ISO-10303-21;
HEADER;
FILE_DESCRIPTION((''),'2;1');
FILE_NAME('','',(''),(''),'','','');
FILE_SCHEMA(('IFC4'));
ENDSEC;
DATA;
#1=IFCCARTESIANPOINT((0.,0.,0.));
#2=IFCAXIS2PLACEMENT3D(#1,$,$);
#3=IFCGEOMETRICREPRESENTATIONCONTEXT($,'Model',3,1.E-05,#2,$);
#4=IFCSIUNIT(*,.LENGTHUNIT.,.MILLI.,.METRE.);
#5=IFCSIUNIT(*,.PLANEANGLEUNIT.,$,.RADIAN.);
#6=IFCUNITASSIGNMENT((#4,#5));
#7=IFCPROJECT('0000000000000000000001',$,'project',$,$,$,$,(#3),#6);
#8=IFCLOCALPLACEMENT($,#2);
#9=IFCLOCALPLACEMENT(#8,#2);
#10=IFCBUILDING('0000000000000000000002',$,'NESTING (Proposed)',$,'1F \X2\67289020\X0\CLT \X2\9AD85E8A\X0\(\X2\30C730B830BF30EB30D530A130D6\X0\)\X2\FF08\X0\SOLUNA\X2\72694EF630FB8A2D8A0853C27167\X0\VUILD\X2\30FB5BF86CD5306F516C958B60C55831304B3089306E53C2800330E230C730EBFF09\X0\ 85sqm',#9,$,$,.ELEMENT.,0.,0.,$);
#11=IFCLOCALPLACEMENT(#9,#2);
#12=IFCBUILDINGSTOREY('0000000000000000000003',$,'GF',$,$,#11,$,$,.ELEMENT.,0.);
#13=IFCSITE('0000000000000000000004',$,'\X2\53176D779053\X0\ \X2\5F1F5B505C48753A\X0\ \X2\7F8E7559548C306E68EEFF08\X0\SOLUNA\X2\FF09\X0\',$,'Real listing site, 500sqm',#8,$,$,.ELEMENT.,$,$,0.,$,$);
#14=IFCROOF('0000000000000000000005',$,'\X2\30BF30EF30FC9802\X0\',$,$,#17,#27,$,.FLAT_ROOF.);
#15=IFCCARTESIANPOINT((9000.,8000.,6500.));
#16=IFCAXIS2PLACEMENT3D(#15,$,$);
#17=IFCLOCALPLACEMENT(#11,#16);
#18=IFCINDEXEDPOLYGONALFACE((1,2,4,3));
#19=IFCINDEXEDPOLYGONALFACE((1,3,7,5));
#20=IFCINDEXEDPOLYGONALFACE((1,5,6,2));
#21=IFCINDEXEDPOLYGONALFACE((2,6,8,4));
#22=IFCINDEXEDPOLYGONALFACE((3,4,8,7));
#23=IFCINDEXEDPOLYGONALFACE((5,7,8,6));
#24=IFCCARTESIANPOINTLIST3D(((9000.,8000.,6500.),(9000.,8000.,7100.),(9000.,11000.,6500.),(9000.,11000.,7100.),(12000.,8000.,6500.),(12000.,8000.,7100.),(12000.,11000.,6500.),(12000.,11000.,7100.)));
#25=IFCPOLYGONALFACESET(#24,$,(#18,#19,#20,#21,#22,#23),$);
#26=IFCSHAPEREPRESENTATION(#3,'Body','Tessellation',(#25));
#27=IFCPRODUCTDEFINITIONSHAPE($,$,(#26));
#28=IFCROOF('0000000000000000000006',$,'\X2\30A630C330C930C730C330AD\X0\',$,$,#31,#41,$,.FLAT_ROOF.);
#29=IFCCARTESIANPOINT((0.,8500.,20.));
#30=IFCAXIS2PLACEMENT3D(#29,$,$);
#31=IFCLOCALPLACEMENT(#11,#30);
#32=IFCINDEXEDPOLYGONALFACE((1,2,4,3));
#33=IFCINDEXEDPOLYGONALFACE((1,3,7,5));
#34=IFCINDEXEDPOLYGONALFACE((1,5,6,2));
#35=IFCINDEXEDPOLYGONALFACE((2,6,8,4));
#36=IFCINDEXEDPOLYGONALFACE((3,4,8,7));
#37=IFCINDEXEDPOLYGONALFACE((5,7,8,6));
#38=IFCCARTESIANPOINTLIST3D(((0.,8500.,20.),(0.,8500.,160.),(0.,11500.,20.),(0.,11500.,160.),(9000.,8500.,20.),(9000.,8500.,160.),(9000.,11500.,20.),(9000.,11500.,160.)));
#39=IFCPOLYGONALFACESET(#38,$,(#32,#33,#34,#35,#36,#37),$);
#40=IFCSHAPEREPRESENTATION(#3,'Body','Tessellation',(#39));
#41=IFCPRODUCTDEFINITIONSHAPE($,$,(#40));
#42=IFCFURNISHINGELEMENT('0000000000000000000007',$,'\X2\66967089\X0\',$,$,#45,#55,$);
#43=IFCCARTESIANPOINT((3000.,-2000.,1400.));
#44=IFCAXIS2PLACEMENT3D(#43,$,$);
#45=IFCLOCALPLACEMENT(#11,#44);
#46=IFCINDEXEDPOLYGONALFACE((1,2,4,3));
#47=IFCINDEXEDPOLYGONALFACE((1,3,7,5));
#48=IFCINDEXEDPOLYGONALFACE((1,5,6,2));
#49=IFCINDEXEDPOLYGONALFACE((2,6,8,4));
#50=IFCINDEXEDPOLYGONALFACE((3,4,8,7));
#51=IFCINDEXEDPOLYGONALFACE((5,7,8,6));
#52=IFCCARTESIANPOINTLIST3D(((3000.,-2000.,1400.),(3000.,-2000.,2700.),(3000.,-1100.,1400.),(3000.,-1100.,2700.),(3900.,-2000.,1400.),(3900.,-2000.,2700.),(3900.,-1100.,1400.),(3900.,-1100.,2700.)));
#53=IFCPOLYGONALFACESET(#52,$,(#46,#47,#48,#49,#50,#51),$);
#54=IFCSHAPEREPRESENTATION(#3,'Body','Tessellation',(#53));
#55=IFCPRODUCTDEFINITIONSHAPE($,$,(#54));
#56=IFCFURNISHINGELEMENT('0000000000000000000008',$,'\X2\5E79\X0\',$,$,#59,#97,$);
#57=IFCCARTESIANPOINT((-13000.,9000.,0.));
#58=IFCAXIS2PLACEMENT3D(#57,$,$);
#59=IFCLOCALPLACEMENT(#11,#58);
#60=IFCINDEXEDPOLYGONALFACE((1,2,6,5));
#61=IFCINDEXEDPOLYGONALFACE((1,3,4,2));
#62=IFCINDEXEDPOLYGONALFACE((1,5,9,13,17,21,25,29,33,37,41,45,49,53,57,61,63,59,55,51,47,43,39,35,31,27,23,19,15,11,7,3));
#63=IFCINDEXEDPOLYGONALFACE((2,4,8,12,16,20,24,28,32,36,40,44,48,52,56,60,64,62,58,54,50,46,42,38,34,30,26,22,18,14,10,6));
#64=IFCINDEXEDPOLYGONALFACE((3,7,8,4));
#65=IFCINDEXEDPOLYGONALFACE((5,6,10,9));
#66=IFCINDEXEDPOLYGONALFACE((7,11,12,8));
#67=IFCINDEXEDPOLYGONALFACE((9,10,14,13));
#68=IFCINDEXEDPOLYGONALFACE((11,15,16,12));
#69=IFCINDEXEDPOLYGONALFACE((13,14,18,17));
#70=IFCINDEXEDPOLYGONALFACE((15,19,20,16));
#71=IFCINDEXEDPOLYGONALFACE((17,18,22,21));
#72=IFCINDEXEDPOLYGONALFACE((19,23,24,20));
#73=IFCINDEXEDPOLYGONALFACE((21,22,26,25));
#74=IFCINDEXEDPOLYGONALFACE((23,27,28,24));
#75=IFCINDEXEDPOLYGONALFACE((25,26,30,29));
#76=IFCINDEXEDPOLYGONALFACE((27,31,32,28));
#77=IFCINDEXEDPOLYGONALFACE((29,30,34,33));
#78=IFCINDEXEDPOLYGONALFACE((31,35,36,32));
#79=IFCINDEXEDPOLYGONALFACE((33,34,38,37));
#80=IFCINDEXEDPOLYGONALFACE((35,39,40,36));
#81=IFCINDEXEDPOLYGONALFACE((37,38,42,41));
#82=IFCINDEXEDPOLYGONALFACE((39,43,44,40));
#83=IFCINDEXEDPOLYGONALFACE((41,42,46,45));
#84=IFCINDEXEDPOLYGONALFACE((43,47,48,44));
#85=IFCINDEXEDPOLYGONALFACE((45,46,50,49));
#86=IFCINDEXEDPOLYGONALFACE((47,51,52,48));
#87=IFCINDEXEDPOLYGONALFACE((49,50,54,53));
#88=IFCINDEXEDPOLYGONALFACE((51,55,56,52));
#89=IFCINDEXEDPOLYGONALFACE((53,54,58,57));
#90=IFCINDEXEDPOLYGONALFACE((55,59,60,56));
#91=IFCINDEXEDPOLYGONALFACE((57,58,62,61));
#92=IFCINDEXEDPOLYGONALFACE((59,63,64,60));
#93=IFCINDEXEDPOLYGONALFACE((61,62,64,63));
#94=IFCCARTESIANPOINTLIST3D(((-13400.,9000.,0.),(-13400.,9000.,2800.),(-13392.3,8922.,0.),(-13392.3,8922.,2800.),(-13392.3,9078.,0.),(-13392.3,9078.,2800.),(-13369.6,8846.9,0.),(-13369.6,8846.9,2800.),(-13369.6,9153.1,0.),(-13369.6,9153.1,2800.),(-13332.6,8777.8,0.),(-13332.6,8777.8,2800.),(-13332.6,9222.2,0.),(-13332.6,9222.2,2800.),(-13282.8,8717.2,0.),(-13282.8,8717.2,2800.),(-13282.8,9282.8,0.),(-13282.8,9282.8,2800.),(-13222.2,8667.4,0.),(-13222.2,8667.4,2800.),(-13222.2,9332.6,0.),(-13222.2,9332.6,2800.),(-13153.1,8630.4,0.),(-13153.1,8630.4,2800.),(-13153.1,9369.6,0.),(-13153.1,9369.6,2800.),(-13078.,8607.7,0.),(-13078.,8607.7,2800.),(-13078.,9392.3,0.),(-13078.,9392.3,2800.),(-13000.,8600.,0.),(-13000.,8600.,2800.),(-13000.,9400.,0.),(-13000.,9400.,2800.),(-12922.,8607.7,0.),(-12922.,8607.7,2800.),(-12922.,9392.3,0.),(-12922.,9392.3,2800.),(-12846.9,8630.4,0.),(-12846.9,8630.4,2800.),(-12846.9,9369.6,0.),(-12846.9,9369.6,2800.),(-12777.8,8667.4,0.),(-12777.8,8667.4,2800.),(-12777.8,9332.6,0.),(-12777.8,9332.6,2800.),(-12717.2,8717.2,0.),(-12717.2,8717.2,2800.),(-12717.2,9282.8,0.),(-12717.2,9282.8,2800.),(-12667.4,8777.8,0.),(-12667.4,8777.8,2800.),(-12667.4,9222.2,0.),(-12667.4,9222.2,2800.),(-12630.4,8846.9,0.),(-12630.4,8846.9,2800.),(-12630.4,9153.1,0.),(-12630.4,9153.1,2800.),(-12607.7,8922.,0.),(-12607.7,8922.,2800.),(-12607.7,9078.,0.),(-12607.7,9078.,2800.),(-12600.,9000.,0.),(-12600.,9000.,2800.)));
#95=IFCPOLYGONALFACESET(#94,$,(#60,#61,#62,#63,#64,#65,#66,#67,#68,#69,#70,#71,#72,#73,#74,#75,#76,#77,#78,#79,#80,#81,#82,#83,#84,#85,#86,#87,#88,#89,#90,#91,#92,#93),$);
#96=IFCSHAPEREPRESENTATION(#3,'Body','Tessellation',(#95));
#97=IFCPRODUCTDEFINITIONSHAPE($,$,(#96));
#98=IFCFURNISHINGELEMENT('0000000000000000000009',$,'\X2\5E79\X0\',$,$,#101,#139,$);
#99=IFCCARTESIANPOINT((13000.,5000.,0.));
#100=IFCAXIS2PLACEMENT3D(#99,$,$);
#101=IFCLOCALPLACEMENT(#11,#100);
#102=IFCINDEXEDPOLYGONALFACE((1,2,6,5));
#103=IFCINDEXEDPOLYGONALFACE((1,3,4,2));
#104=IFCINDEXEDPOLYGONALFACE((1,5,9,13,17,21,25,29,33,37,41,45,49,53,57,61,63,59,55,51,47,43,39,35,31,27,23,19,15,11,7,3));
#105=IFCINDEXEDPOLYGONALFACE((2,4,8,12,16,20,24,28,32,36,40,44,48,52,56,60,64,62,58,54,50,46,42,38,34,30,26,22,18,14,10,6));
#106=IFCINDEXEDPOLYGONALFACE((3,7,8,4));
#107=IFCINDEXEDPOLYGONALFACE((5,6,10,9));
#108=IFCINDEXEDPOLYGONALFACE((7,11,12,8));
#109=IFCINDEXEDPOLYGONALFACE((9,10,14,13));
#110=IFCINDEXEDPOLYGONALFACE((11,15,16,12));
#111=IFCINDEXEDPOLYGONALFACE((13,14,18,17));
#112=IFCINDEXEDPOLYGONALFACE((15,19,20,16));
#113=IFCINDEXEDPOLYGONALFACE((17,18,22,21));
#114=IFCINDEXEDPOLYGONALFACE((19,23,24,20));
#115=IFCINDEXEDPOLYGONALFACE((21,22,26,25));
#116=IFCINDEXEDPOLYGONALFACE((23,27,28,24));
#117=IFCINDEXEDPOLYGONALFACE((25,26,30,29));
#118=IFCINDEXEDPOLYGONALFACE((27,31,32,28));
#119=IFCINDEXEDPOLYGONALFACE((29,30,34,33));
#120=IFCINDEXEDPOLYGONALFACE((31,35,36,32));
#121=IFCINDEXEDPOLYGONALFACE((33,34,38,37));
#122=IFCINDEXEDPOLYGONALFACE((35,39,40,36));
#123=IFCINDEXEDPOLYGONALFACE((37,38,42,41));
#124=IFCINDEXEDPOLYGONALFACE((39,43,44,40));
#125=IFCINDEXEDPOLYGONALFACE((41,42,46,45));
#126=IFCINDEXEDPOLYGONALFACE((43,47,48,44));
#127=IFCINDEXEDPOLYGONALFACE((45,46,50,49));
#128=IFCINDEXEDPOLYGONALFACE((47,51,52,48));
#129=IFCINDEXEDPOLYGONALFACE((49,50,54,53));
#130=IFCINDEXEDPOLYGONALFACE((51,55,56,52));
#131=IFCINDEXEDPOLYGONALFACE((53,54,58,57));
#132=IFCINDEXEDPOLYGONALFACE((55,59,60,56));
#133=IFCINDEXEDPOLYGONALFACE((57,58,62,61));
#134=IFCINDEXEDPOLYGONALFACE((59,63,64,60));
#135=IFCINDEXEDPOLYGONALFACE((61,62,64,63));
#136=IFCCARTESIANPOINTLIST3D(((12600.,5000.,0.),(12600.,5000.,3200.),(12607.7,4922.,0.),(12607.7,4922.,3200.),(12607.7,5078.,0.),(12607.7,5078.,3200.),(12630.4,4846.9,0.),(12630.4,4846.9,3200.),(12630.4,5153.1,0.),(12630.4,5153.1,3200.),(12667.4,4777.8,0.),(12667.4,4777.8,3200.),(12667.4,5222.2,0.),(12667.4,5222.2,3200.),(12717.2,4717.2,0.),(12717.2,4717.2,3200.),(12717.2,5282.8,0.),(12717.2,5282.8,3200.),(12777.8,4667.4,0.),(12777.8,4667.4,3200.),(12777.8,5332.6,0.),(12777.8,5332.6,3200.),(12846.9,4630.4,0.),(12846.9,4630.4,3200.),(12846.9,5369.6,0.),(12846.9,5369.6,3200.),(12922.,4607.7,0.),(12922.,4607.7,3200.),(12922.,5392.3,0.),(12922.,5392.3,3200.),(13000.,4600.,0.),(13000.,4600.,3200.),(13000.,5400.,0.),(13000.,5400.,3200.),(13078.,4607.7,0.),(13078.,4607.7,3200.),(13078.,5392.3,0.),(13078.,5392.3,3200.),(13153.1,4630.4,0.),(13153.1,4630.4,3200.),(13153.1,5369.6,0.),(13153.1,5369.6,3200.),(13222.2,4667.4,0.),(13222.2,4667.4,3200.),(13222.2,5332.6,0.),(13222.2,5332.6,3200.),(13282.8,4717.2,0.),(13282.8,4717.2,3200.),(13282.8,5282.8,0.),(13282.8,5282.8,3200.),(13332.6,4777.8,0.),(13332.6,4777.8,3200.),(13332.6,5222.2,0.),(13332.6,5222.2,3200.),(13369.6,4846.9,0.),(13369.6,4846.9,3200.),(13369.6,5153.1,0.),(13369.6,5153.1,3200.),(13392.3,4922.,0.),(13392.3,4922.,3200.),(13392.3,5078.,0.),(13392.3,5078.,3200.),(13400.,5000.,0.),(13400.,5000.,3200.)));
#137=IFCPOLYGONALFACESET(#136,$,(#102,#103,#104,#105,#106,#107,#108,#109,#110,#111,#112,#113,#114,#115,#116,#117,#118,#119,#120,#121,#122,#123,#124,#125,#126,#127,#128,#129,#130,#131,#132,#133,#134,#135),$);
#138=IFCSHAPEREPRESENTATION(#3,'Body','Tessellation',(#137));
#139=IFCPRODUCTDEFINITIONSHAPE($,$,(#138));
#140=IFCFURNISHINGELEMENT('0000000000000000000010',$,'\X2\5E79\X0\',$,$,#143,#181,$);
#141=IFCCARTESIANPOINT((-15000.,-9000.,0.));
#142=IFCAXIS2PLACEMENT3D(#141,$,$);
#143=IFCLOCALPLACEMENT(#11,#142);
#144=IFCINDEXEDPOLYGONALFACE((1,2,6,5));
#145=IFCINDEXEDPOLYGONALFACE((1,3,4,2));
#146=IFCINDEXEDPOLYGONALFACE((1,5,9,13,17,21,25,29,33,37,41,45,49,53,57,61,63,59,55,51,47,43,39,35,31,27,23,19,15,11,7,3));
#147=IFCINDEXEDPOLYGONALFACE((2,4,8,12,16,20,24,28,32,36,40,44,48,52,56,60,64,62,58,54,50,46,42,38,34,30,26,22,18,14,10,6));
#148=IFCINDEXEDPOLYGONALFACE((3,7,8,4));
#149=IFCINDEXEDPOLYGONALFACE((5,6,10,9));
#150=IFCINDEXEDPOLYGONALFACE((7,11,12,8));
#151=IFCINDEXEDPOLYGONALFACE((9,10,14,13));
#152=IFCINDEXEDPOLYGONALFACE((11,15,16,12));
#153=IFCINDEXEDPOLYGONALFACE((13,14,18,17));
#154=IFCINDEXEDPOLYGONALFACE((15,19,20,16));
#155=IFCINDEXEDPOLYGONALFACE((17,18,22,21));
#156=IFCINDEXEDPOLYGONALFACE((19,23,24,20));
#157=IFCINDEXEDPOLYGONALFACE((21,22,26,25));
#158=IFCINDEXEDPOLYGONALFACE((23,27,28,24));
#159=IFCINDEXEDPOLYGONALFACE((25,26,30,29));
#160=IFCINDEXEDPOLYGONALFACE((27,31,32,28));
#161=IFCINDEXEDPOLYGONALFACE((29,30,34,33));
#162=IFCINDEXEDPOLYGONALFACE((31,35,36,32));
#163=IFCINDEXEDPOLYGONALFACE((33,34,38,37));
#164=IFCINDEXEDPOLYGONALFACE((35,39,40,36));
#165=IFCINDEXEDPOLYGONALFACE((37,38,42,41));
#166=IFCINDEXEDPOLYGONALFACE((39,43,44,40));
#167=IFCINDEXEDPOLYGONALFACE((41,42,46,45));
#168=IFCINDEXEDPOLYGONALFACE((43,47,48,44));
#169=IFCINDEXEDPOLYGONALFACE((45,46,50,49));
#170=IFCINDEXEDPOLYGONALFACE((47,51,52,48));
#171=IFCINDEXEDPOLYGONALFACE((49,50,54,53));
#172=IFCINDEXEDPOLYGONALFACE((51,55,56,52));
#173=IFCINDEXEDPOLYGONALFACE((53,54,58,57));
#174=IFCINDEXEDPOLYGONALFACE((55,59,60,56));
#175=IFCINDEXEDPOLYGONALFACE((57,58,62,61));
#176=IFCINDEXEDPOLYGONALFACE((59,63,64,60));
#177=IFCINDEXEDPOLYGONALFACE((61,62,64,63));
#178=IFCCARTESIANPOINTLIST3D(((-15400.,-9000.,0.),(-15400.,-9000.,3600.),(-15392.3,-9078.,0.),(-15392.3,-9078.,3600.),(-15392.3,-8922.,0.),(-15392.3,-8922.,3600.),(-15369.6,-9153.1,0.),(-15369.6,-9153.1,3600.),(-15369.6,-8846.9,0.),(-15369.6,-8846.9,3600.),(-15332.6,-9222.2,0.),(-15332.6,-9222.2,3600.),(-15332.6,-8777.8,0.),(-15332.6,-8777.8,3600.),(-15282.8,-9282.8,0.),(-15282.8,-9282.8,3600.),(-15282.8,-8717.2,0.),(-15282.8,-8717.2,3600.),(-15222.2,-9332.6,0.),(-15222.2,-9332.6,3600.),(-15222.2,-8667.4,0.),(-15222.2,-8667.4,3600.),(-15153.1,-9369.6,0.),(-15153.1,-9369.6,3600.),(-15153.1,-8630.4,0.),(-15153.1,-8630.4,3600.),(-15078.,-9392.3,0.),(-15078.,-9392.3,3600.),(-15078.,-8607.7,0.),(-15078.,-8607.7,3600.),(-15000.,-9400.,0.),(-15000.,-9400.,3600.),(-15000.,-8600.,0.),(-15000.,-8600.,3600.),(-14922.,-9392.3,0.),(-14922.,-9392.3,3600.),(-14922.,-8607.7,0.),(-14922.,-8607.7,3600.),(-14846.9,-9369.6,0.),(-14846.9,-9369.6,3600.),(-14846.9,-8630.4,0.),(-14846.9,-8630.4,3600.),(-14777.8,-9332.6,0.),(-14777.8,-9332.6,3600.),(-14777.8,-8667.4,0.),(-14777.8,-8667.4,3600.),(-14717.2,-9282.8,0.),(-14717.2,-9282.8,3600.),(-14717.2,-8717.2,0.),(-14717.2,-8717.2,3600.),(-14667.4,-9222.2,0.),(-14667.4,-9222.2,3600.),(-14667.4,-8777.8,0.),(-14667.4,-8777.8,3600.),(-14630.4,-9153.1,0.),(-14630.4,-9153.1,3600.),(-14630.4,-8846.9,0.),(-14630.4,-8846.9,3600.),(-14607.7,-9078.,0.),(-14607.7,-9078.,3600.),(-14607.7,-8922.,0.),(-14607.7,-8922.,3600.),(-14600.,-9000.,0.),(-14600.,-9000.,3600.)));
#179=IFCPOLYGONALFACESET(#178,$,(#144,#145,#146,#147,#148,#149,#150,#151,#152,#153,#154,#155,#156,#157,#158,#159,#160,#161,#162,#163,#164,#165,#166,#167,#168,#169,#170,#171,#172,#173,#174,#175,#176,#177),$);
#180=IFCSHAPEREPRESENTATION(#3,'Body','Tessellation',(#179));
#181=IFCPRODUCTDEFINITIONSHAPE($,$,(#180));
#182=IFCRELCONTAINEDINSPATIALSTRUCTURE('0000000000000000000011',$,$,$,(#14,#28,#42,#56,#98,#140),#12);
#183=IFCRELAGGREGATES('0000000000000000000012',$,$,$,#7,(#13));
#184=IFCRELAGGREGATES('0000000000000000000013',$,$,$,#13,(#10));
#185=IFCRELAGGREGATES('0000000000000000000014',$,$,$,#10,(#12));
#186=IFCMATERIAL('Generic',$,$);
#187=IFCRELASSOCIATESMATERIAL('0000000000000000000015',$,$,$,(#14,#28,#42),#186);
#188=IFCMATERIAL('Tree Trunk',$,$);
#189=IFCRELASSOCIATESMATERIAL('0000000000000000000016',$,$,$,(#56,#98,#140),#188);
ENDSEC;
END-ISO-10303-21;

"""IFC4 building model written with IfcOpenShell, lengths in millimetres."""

from ifc_helpers import new_model, si_unit, frame, frame_2d, origin, origin_2d, place, context, project, spatial, rectangle, circle, extrude, material, element, save


model = new_model("IFC4")

# Units and contexts
model_context = context("Model", 3, precision=1e-05, world=origin())
ifc_project = project(units=[si_unit("LENGTHUNIT", "METRE", prefix="MILLI"), si_unit("PLANEANGLEUNIT", "RADIAN")], contexts=[model_context])

# Site, building, storey
site_placement = place(None, origin())
site = spatial("IfcSite", under=ifc_project, at=site_placement, Name="北海道 弟子屈町 美留和の森（SOLUNA）", ObjectType="Real listing site, 500sqm", CompositionType="ELEMENT", RefElevation=0.0)
building_placement = place(site_placement, origin())
building = spatial("IfcBuilding", under=site, at=building_placement, Name="NESTING (Proposed)", ObjectType="1F 木造CLT 高床(デジタルファブ)（SOLUNA物件・設計参照VUILD・寸法は公開情報からの参考モデル） 85sqm", CompositionType="ELEMENT", ElevationOfRefHeight=0.0, ElevationOfTerrain=0.0)
storey_placement = place(building_placement, origin())
storey = spatial("IfcBuildingStorey", under=building, at=storey_placement, Name="GF", CompositionType="ELEMENT", Elevation=0.0)

# Shared definitions
ifc_material_1 = material(Name="Generic")

# Roofs
roof_1_placement = place(storey_placement, frame((9000.0, 8000.0, 6500.0)))
element("IfcRoof", 1, at=roof_1_placement, inside=storey, material=ifc_material_1, Name="タワー頂", PredefinedType="FLAT_ROOF", context=model_context, shape_type="SweptSolid", body=[
    extrude(rectangle(XDim=3000.0, YDim=3000.0, at=frame_2d((1500.0, 1500.0))), frame((9000.0, 8000.0, 6500.0)), (0.0, 0.0, 1.0), 600.0),
])
roof_2_placement = place(storey_placement, frame((0.0, 8500.0, 20.0)))
element("IfcRoof", 2, at=roof_2_placement, inside=storey, material=ifc_material_1, Name="ウッドデッキ", PredefinedType="FLAT_ROOF", context=model_context, shape_type="SweptSolid", body=[
    extrude(rectangle(XDim=9000.0, YDim=3000.0, at=frame_2d((4500.0, 1500.0))), frame((0.0, 8500.0, 20.0)), (0.0, 0.0, 1.0), 140.0),
])

# Furnishing elements
furnishing_1_placement = place(storey_placement, frame((3000.0, -2000.0, 1400.0)))
element("IfcFurnishingElement", 3, at=furnishing_1_placement, inside=storey, material=ifc_material_1, Name="暖炉", context=model_context, shape_type="SweptSolid", body=[
    extrude(rectangle(XDim=900.0, YDim=900.0, at=frame_2d((450.0, 450.0))), frame((3000.0, -2000.0, 1400.0)), (0.0, 0.0, 1.0), 1300.0),
])
ifc_material_2 = material(Name="Tree Trunk")
furnishing_2_placement = place(storey_placement, frame((-13000.0, 9000.0, 0.0)))
element("IfcFurnishingElement", 4, at=furnishing_2_placement, inside=storey, material=ifc_material_2, Name="幹", context=model_context, shape_type="SweptSolid", body=[
    extrude(circle(Radius=400.0, at=origin_2d()), frame((-13000.0, 9000.0, 0.0)), (0.0, 0.0, 1.0), 2800.0),
])
furnishing_3_placement = place(storey_placement, frame((13000.0, 5000.0, 0.0)))
element("IfcFurnishingElement", 5, at=furnishing_3_placement, inside=storey, material=ifc_material_2, Name="幹", context=model_context, shape_type="SweptSolid", body=[
    extrude(circle(Radius=400.0, at=origin_2d()), frame((13000.0, 5000.0, 0.0)), (0.0, 0.0, 1.0), 3200.0),
])
furnishing_4_placement = place(storey_placement, frame((-15000.0, -9000.0, 0.0)))
element("IfcFurnishingElement", 6, at=furnishing_4_placement, inside=storey, material=ifc_material_2, Name="幹", context=model_context, shape_type="SweptSolid", body=[
    extrude(circle(Radius=400.0, at=origin_2d()), frame((-15000.0, -9000.0, 0.0)), (0.0, 0.0, 1.0), 3600.0),
])

save(model, "model.ifc")
